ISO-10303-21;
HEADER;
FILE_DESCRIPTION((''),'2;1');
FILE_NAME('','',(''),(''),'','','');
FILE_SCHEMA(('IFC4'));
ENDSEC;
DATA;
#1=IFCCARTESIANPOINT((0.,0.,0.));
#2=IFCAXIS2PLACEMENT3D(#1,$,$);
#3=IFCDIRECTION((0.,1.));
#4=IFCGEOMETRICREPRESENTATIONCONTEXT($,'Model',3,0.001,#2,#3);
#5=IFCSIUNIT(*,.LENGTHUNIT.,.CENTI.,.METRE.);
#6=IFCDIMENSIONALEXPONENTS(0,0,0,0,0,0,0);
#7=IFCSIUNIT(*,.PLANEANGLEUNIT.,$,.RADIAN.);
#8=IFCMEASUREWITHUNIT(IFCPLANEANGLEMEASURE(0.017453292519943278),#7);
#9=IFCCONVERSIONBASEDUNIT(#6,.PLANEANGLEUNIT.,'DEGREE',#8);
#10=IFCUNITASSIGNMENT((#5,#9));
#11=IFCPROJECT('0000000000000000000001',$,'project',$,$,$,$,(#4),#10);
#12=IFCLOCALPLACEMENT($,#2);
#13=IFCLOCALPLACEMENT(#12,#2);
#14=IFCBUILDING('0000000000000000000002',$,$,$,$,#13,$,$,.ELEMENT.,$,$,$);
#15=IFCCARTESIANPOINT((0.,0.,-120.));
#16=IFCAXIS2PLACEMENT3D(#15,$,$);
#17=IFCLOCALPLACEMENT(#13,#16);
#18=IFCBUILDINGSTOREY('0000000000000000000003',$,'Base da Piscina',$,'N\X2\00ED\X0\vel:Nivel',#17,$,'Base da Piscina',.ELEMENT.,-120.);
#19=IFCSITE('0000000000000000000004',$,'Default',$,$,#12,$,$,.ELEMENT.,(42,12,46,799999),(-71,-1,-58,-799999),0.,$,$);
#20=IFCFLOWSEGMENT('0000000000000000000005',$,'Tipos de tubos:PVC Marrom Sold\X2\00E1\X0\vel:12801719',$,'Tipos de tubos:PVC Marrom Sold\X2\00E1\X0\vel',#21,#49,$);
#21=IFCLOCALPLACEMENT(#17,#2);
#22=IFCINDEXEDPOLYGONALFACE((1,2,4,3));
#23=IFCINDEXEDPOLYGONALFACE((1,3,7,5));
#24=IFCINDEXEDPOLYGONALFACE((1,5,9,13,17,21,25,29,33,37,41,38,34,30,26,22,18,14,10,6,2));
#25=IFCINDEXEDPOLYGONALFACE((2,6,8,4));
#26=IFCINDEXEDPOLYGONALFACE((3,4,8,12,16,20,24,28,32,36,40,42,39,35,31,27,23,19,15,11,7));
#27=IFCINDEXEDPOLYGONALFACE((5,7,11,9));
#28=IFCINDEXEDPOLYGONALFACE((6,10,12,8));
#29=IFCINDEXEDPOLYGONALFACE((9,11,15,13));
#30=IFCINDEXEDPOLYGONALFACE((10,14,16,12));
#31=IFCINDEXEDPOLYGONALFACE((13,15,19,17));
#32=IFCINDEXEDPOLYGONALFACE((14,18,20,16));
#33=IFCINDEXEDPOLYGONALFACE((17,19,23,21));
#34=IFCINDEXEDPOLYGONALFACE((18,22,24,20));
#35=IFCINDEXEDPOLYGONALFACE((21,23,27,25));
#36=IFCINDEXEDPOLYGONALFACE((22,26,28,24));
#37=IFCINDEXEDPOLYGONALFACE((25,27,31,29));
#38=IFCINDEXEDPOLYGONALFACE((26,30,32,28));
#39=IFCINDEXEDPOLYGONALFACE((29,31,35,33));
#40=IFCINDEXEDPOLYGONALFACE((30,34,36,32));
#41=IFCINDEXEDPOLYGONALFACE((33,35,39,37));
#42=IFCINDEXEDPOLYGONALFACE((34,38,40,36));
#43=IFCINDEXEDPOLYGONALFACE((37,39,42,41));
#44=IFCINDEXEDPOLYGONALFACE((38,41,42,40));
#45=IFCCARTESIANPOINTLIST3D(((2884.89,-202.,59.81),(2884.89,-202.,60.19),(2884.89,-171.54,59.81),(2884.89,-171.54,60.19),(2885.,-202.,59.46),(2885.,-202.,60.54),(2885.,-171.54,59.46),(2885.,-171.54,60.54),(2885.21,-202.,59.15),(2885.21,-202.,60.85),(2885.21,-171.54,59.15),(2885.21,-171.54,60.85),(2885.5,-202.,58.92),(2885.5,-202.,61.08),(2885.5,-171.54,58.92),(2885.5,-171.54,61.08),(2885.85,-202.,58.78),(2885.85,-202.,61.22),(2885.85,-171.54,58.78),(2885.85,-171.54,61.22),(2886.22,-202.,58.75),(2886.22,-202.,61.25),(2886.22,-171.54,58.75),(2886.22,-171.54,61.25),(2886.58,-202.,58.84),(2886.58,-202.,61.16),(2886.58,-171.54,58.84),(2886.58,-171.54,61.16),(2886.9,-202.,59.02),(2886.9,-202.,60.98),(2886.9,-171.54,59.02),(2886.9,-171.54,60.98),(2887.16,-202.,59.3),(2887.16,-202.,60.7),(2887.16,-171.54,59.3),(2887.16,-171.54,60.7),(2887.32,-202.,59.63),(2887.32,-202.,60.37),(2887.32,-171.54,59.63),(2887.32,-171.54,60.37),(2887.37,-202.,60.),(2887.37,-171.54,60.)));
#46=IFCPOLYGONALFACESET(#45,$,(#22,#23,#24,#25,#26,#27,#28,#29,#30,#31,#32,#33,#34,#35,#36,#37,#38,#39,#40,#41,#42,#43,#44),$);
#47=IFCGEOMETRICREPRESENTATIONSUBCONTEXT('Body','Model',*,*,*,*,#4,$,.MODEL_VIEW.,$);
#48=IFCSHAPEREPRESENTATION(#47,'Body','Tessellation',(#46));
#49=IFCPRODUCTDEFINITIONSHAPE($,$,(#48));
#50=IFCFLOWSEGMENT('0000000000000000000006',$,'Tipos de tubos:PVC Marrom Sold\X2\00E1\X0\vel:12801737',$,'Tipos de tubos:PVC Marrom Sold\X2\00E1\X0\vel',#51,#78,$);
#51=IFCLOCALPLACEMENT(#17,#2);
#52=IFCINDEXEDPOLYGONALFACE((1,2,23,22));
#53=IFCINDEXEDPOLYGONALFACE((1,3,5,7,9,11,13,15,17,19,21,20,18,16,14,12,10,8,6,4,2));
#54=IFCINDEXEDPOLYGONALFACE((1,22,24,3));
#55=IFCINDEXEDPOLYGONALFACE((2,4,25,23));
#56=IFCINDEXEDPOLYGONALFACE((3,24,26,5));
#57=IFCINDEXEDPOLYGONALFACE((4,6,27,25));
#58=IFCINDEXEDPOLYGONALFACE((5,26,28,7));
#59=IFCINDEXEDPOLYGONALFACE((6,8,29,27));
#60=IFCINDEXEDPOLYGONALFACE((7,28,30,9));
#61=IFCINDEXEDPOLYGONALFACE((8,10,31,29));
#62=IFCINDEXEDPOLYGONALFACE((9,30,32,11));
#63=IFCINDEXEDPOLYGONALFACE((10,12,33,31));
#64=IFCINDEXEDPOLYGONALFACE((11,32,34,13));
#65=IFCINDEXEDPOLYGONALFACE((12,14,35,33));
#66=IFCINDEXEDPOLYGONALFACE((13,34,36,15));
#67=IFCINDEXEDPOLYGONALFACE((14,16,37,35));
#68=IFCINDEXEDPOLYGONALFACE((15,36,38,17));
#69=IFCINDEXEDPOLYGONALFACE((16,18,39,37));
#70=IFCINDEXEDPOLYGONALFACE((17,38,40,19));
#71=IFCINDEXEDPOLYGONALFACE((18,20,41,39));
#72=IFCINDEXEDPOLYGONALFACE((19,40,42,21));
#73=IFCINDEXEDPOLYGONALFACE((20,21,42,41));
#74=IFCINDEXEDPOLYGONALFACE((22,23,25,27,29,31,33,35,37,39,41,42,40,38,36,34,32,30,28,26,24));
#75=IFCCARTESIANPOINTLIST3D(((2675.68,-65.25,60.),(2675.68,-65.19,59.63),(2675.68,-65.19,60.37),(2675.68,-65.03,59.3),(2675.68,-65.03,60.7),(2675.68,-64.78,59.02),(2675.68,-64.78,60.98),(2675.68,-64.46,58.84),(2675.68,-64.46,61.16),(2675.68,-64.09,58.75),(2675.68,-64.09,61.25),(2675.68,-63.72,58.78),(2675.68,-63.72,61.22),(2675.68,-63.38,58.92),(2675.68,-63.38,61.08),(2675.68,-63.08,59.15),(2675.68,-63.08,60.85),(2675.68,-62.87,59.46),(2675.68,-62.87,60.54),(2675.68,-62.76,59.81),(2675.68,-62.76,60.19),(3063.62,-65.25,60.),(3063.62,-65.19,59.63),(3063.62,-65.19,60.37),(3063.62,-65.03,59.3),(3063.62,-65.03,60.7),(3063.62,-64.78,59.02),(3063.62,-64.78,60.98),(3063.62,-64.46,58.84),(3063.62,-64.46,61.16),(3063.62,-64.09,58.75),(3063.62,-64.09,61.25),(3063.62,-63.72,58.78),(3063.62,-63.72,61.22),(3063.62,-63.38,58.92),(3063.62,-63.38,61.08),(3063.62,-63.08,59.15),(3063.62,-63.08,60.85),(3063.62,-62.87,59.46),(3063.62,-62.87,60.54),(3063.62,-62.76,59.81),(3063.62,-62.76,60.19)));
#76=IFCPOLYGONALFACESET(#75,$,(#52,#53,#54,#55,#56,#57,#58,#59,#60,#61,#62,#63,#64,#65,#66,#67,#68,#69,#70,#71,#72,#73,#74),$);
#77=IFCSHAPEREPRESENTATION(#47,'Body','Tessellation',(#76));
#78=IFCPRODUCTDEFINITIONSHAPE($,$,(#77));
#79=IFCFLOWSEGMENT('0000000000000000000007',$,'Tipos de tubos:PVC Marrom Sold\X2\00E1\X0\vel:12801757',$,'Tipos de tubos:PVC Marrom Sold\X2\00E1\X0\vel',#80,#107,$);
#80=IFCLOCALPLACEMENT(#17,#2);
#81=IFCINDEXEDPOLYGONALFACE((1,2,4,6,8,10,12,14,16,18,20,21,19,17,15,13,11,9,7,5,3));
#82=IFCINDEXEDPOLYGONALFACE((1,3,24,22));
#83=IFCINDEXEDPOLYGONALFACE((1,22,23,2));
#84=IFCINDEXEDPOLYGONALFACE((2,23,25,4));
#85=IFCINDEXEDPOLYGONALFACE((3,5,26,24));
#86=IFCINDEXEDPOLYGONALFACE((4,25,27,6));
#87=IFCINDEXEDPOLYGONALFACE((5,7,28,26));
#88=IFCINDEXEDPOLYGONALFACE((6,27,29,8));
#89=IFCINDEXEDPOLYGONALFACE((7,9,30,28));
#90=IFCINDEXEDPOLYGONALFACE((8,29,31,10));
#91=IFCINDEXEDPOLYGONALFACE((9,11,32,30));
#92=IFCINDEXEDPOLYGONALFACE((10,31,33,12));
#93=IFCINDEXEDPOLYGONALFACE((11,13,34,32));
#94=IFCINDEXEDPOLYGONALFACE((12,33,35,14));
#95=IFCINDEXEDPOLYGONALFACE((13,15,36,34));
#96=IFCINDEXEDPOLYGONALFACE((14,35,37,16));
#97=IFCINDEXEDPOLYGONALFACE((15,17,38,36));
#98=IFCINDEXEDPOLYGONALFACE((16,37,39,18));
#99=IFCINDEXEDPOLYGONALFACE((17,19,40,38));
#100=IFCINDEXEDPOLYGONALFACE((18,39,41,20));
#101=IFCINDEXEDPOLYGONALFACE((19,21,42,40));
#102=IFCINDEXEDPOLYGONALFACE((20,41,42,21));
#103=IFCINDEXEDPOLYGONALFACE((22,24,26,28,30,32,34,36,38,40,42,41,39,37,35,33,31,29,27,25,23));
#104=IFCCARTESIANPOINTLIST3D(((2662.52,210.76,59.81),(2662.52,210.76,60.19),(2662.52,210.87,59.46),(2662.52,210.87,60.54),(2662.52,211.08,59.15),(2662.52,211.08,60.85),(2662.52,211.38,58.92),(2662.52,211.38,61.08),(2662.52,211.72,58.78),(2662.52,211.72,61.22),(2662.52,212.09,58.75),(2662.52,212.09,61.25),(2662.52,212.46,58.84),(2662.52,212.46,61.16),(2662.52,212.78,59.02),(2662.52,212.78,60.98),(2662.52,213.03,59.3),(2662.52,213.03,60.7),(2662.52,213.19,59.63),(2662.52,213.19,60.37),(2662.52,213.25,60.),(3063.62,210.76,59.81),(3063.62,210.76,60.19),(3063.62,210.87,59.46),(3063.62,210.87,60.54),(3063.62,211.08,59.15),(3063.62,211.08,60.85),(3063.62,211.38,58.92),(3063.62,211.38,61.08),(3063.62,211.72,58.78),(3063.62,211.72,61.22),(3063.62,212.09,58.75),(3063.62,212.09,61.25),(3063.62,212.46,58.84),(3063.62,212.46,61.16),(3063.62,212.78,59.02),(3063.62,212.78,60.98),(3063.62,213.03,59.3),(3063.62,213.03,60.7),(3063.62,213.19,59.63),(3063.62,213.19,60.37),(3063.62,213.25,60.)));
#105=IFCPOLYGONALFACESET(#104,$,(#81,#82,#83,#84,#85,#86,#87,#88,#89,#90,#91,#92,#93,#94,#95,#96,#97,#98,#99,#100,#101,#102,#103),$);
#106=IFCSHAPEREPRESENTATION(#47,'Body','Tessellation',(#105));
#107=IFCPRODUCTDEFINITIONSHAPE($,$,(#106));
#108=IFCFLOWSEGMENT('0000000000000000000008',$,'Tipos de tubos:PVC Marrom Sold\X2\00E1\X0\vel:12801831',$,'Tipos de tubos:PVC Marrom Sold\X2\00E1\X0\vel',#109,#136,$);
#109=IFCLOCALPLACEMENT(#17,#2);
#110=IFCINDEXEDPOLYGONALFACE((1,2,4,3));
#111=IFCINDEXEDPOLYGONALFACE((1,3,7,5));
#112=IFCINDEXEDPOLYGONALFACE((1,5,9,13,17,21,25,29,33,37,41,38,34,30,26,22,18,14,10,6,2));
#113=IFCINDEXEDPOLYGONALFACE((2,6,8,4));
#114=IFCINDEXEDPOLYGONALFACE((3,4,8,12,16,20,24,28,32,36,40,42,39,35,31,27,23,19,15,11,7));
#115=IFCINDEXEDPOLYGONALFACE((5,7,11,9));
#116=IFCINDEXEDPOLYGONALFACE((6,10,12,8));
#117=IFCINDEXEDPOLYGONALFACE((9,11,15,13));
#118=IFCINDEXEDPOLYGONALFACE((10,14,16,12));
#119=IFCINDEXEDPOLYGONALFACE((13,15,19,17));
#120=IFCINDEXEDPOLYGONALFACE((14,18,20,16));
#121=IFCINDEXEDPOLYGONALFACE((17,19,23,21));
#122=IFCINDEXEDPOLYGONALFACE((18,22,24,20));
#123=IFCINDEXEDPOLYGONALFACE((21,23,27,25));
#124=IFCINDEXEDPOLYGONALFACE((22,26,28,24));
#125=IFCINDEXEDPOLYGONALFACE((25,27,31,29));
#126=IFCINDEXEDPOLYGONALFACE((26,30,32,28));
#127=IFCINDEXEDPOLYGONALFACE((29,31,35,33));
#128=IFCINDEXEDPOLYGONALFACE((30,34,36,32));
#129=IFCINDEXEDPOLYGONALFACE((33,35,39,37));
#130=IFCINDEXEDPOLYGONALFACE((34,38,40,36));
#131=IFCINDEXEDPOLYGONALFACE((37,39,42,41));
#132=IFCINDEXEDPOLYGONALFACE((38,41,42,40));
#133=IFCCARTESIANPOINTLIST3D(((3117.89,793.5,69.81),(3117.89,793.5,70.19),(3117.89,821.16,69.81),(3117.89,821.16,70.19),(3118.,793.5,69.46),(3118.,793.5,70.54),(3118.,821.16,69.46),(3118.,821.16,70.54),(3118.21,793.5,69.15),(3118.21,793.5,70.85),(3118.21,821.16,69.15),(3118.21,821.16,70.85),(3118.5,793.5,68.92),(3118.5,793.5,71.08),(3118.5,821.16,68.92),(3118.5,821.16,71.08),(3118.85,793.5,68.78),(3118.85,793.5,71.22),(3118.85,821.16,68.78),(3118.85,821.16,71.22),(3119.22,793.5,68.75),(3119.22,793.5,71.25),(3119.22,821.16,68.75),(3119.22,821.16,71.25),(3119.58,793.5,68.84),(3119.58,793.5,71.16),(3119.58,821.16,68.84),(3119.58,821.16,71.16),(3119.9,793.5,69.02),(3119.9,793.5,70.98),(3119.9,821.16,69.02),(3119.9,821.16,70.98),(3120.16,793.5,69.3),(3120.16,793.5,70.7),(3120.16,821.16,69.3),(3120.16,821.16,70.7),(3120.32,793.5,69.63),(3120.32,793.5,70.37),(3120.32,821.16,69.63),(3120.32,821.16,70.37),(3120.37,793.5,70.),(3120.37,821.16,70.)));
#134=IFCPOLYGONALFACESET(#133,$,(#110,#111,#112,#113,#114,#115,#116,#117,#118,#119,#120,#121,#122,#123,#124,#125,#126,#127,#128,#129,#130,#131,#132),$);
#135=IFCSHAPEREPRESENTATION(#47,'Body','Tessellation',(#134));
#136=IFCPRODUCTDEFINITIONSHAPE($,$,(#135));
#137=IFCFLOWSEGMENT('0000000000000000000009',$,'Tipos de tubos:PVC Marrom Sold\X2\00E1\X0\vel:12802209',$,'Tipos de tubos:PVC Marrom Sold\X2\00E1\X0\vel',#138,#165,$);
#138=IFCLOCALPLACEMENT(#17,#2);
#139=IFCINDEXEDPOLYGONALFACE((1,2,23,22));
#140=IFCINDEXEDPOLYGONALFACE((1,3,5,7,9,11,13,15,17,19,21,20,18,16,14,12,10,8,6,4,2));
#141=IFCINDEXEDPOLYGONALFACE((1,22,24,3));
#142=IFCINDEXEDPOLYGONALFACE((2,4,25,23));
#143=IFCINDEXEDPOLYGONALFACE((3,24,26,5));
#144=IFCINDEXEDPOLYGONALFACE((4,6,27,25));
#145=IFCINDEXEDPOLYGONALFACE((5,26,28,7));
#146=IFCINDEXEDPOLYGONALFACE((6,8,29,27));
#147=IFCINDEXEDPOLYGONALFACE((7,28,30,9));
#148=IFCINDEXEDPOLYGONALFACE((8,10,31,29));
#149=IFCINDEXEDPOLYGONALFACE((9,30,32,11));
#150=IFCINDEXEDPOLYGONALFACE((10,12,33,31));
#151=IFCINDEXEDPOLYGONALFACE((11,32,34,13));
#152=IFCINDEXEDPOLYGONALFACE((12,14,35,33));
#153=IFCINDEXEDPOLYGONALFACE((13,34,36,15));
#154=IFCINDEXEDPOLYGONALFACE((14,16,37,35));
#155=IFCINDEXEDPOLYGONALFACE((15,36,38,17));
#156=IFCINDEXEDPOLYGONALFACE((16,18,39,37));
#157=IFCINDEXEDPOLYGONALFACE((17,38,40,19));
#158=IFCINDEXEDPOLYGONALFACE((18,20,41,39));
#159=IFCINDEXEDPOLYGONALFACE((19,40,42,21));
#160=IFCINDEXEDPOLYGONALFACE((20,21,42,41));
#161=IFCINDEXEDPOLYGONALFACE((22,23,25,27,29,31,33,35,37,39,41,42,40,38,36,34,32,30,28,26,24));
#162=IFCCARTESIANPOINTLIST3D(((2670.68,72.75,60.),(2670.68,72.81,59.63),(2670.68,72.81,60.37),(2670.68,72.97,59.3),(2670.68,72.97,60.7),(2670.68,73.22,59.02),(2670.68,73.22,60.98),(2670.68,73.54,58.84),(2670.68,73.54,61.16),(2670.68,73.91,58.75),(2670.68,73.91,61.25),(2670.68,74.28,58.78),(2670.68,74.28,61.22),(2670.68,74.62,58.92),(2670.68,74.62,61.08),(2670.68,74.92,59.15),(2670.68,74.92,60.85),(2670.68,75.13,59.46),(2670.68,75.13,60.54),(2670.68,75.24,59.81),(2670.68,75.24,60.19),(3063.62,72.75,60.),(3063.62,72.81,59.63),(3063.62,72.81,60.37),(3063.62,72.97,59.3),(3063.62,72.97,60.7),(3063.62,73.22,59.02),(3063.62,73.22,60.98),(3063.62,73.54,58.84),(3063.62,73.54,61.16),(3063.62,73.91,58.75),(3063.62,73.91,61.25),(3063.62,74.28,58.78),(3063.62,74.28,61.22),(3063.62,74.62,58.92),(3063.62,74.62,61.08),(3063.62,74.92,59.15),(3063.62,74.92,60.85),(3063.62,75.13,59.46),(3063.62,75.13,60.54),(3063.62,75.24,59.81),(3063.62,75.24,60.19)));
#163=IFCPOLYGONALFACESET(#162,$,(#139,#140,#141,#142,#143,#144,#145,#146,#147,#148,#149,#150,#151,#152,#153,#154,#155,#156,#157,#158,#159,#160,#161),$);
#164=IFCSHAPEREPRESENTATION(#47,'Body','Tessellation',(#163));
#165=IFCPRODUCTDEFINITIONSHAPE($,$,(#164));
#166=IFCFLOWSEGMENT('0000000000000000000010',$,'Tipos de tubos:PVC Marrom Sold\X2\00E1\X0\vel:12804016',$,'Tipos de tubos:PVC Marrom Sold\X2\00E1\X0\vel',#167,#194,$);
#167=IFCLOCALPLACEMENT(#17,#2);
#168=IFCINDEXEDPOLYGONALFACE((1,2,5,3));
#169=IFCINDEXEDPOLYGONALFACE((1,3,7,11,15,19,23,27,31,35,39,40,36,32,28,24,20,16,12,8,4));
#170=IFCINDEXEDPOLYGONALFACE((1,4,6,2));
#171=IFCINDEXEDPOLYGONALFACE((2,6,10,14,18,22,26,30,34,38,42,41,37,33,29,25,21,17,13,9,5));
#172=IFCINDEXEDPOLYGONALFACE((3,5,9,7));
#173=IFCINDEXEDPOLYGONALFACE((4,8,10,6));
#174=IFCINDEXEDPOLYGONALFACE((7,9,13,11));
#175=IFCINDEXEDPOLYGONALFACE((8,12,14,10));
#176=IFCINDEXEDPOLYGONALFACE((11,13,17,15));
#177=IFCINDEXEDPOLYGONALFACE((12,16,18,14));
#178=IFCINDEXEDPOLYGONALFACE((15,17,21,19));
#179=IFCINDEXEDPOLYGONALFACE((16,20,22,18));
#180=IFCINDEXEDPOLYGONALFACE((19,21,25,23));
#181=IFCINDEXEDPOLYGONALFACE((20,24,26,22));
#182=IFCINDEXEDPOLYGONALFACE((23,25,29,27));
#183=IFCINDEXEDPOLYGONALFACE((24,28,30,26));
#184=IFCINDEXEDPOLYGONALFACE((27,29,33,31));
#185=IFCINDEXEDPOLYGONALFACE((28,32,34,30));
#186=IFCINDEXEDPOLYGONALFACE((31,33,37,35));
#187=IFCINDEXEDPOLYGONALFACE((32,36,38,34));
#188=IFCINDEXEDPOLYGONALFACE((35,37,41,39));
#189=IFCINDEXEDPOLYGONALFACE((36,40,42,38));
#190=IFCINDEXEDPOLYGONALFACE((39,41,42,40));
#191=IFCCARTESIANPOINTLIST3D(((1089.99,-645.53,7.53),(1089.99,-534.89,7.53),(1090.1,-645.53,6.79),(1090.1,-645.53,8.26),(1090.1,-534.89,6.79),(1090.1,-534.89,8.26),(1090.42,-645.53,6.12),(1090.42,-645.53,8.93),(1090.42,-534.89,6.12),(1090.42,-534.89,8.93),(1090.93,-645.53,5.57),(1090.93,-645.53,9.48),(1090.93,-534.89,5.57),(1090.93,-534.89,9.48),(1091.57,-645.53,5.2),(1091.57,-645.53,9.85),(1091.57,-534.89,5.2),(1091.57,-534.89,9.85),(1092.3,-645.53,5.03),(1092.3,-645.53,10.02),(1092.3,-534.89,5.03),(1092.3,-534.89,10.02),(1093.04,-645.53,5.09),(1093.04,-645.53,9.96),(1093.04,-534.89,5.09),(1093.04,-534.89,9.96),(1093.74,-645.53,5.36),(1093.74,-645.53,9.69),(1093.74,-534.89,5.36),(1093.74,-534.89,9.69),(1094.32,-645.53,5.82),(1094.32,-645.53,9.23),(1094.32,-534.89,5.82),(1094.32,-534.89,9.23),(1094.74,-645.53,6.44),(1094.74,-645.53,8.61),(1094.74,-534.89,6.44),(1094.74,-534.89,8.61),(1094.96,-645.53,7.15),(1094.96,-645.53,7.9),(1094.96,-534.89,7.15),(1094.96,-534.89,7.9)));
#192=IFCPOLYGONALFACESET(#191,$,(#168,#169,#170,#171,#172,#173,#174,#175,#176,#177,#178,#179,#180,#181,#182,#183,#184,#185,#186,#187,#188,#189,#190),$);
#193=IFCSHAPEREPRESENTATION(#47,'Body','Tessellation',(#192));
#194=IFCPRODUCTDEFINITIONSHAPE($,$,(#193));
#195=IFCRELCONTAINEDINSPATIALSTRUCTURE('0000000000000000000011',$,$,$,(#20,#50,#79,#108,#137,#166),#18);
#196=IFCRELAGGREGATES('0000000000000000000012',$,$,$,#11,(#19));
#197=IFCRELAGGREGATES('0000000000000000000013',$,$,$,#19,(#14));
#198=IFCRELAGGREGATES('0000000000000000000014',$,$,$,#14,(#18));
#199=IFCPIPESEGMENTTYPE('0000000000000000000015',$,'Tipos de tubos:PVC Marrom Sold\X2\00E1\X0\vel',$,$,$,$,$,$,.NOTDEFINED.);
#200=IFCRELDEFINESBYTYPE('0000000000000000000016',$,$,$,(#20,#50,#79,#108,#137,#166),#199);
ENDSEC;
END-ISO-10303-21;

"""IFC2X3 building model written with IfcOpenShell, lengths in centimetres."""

from ifc_helpers import new_model, entity, si_unit, converted_unit, direction, frame, frame_2d, origin, origin_2d_with_axis, place, context, subcontext, project, spatial, circle, extrude, type_object, element, save


model = new_model("IFC2X3")

# Units and contexts
model_context = context("Model", 3, precision=0.001, world=origin(), true_north=direction((0.0, 1.0)))
body_context = subcontext(model_context, "Body", "Model", "MODEL_VIEW")
ifc_project = project(units=[si_unit("LENGTHUNIT", "METRE", prefix="CENTI"), converted_unit("PLANEANGLEUNIT", "DEGREE", entity("IfcPlaneAngleMeasure", 0.017453292519943278), si_unit("PLANEANGLEUNIT", "RADIAN"), dimensions=[0, 0, 0, 0, 0, 0, 0])], contexts=[model_context])

# Site, building, storey
site_placement = place(None, origin())
site = spatial("IfcSite", under=ifc_project, at=site_placement, Name="Default", CompositionType="ELEMENT", RefLatitude=(42, 12, 46, 799999), RefLongitude=(-71, -1, -58, -799999), RefElevation=0.0)
building_placement = place(site_placement, origin())
building = spatial("IfcBuilding", under=site, at=building_placement, CompositionType="ELEMENT")
storey_placement = place(building_placement, frame((0.0, 0.0, -120.0)))
storey = spatial("IfcBuildingStorey", under=building, at=storey_placement, Name="Base da Piscina", ObjectType="Nível:Nivel", LongName="Base da Piscina", CompositionType="ELEMENT", Elevation=-120.0)

# Flow segments
pipe_segment_type = type_object("IfcPipeSegmentType", Name="Tipos de tubos:PVC Marrom Soldável", PredefinedType="NOTDEFINED")
flow_segment_1_placement = place(storey_placement, origin())
element("IfcFlowSegment", 1, at=flow_segment_1_placement, inside=storey, type_object=pipe_segment_type, Name="Tipos de tubos:PVC Marrom Soldável:12801719", ObjectType="Tipos de tubos:PVC Marrom Soldável", context=body_context, shape_type="SweptSolid", body=[
    extrude(circle(Radius=1.25, at=origin_2d_with_axis()), frame((2886.12, -202.0, 60.0), z_axis=(0.0, 1.0, 0.0), x_axis=(1.0, 0.0, 0.0)), (0.0, 0.0, 1.0), 30.46),
])
flow_segment_2_placement = place(storey_placement, origin())
element("IfcFlowSegment", 2, at=flow_segment_2_placement, inside=storey, type_object=pipe_segment_type, Name="Tipos de tubos:PVC Marrom Soldável:12801737", ObjectType="Tipos de tubos:PVC Marrom Soldável", context=body_context, shape_type="SweptSolid", body=[
    extrude(circle(Radius=1.25, at=origin_2d_with_axis()), frame((2675.68, -64.0, 60.0), z_axis=(1.0, 0.0, 0.0), x_axis=(0.0, -1.0, 0.0)), (0.0, 0.0, 1.0), 387.94),
])
flow_segment_3_placement = place(storey_placement, origin())
element("IfcFlowSegment", 3, at=flow_segment_3_placement, inside=storey, type_object=pipe_segment_type, Name="Tipos de tubos:PVC Marrom Soldável:12801757", ObjectType="Tipos de tubos:PVC Marrom Soldável", context=body_context, shape_type="SweptSolid", body=[
    extrude(circle(Radius=1.25, at=frame_2d((0.0, 0.0), x_axis=(1.0, 0.0))), frame((2662.52, 212.0, 60.0), z_axis=(1.0, 0.0, 0.0), x_axis=(0.0, 1.0, 0.0)), (0.0, 0.0, 1.0), 401.1),
])
flow_segment_4_placement = place(storey_placement, origin())
element("IfcFlowSegment", 4, at=flow_segment_4_placement, inside=storey, type_object=pipe_segment_type, Name="Tipos de tubos:PVC Marrom Soldável:12801831", ObjectType="Tipos de tubos:PVC Marrom Soldável", context=body_context, shape_type="SweptSolid", body=[
    extrude(circle(Radius=1.25, at=origin_2d_with_axis()), frame((3119.12, 793.5, 70.0), z_axis=(0.0, 1.0, 0.0), x_axis=(1.0, 0.0, 0.0)), (0.0, 0.0, 1.0), 27.66),
])
flow_segment_5_placement = place(storey_placement, origin())
element("IfcFlowSegment", 5, at=flow_segment_5_placement, inside=storey, type_object=pipe_segment_type, Name="Tipos de tubos:PVC Marrom Soldável:12802209", ObjectType="Tipos de tubos:PVC Marrom Soldável", context=body_context, shape_type="SweptSolid", body=[
    extrude(circle(Radius=1.25, at=origin_2d_with_axis()), frame((2670.68, 74.0, 60.0), z_axis=(1.0, 0.0, 0.0), x_axis=(0.0, -1.0, 0.0)), (0.0, 0.0, 1.0), 392.94),
])
flow_segment_6_placement = place(storey_placement, origin())
element("IfcFlowSegment", 6, at=flow_segment_6_placement, inside=storey, type_object=pipe_segment_type, Name="Tipos de tubos:PVC Marrom Soldável:12804016", ObjectType="Tipos de tubos:PVC Marrom Soldável", context=body_context, shape_type="SweptSolid", body=[
    extrude(circle(Radius=2.5, at=origin_2d_with_axis()), frame((1092.49, -645.53, 7.53), z_axis=(0.0, 1.0, 0.0), x_axis=(-1.0, 0.0, 0.0)), (0.0, 0.0, 1.0), 110.64),
])

save(model, "model.ifc")
